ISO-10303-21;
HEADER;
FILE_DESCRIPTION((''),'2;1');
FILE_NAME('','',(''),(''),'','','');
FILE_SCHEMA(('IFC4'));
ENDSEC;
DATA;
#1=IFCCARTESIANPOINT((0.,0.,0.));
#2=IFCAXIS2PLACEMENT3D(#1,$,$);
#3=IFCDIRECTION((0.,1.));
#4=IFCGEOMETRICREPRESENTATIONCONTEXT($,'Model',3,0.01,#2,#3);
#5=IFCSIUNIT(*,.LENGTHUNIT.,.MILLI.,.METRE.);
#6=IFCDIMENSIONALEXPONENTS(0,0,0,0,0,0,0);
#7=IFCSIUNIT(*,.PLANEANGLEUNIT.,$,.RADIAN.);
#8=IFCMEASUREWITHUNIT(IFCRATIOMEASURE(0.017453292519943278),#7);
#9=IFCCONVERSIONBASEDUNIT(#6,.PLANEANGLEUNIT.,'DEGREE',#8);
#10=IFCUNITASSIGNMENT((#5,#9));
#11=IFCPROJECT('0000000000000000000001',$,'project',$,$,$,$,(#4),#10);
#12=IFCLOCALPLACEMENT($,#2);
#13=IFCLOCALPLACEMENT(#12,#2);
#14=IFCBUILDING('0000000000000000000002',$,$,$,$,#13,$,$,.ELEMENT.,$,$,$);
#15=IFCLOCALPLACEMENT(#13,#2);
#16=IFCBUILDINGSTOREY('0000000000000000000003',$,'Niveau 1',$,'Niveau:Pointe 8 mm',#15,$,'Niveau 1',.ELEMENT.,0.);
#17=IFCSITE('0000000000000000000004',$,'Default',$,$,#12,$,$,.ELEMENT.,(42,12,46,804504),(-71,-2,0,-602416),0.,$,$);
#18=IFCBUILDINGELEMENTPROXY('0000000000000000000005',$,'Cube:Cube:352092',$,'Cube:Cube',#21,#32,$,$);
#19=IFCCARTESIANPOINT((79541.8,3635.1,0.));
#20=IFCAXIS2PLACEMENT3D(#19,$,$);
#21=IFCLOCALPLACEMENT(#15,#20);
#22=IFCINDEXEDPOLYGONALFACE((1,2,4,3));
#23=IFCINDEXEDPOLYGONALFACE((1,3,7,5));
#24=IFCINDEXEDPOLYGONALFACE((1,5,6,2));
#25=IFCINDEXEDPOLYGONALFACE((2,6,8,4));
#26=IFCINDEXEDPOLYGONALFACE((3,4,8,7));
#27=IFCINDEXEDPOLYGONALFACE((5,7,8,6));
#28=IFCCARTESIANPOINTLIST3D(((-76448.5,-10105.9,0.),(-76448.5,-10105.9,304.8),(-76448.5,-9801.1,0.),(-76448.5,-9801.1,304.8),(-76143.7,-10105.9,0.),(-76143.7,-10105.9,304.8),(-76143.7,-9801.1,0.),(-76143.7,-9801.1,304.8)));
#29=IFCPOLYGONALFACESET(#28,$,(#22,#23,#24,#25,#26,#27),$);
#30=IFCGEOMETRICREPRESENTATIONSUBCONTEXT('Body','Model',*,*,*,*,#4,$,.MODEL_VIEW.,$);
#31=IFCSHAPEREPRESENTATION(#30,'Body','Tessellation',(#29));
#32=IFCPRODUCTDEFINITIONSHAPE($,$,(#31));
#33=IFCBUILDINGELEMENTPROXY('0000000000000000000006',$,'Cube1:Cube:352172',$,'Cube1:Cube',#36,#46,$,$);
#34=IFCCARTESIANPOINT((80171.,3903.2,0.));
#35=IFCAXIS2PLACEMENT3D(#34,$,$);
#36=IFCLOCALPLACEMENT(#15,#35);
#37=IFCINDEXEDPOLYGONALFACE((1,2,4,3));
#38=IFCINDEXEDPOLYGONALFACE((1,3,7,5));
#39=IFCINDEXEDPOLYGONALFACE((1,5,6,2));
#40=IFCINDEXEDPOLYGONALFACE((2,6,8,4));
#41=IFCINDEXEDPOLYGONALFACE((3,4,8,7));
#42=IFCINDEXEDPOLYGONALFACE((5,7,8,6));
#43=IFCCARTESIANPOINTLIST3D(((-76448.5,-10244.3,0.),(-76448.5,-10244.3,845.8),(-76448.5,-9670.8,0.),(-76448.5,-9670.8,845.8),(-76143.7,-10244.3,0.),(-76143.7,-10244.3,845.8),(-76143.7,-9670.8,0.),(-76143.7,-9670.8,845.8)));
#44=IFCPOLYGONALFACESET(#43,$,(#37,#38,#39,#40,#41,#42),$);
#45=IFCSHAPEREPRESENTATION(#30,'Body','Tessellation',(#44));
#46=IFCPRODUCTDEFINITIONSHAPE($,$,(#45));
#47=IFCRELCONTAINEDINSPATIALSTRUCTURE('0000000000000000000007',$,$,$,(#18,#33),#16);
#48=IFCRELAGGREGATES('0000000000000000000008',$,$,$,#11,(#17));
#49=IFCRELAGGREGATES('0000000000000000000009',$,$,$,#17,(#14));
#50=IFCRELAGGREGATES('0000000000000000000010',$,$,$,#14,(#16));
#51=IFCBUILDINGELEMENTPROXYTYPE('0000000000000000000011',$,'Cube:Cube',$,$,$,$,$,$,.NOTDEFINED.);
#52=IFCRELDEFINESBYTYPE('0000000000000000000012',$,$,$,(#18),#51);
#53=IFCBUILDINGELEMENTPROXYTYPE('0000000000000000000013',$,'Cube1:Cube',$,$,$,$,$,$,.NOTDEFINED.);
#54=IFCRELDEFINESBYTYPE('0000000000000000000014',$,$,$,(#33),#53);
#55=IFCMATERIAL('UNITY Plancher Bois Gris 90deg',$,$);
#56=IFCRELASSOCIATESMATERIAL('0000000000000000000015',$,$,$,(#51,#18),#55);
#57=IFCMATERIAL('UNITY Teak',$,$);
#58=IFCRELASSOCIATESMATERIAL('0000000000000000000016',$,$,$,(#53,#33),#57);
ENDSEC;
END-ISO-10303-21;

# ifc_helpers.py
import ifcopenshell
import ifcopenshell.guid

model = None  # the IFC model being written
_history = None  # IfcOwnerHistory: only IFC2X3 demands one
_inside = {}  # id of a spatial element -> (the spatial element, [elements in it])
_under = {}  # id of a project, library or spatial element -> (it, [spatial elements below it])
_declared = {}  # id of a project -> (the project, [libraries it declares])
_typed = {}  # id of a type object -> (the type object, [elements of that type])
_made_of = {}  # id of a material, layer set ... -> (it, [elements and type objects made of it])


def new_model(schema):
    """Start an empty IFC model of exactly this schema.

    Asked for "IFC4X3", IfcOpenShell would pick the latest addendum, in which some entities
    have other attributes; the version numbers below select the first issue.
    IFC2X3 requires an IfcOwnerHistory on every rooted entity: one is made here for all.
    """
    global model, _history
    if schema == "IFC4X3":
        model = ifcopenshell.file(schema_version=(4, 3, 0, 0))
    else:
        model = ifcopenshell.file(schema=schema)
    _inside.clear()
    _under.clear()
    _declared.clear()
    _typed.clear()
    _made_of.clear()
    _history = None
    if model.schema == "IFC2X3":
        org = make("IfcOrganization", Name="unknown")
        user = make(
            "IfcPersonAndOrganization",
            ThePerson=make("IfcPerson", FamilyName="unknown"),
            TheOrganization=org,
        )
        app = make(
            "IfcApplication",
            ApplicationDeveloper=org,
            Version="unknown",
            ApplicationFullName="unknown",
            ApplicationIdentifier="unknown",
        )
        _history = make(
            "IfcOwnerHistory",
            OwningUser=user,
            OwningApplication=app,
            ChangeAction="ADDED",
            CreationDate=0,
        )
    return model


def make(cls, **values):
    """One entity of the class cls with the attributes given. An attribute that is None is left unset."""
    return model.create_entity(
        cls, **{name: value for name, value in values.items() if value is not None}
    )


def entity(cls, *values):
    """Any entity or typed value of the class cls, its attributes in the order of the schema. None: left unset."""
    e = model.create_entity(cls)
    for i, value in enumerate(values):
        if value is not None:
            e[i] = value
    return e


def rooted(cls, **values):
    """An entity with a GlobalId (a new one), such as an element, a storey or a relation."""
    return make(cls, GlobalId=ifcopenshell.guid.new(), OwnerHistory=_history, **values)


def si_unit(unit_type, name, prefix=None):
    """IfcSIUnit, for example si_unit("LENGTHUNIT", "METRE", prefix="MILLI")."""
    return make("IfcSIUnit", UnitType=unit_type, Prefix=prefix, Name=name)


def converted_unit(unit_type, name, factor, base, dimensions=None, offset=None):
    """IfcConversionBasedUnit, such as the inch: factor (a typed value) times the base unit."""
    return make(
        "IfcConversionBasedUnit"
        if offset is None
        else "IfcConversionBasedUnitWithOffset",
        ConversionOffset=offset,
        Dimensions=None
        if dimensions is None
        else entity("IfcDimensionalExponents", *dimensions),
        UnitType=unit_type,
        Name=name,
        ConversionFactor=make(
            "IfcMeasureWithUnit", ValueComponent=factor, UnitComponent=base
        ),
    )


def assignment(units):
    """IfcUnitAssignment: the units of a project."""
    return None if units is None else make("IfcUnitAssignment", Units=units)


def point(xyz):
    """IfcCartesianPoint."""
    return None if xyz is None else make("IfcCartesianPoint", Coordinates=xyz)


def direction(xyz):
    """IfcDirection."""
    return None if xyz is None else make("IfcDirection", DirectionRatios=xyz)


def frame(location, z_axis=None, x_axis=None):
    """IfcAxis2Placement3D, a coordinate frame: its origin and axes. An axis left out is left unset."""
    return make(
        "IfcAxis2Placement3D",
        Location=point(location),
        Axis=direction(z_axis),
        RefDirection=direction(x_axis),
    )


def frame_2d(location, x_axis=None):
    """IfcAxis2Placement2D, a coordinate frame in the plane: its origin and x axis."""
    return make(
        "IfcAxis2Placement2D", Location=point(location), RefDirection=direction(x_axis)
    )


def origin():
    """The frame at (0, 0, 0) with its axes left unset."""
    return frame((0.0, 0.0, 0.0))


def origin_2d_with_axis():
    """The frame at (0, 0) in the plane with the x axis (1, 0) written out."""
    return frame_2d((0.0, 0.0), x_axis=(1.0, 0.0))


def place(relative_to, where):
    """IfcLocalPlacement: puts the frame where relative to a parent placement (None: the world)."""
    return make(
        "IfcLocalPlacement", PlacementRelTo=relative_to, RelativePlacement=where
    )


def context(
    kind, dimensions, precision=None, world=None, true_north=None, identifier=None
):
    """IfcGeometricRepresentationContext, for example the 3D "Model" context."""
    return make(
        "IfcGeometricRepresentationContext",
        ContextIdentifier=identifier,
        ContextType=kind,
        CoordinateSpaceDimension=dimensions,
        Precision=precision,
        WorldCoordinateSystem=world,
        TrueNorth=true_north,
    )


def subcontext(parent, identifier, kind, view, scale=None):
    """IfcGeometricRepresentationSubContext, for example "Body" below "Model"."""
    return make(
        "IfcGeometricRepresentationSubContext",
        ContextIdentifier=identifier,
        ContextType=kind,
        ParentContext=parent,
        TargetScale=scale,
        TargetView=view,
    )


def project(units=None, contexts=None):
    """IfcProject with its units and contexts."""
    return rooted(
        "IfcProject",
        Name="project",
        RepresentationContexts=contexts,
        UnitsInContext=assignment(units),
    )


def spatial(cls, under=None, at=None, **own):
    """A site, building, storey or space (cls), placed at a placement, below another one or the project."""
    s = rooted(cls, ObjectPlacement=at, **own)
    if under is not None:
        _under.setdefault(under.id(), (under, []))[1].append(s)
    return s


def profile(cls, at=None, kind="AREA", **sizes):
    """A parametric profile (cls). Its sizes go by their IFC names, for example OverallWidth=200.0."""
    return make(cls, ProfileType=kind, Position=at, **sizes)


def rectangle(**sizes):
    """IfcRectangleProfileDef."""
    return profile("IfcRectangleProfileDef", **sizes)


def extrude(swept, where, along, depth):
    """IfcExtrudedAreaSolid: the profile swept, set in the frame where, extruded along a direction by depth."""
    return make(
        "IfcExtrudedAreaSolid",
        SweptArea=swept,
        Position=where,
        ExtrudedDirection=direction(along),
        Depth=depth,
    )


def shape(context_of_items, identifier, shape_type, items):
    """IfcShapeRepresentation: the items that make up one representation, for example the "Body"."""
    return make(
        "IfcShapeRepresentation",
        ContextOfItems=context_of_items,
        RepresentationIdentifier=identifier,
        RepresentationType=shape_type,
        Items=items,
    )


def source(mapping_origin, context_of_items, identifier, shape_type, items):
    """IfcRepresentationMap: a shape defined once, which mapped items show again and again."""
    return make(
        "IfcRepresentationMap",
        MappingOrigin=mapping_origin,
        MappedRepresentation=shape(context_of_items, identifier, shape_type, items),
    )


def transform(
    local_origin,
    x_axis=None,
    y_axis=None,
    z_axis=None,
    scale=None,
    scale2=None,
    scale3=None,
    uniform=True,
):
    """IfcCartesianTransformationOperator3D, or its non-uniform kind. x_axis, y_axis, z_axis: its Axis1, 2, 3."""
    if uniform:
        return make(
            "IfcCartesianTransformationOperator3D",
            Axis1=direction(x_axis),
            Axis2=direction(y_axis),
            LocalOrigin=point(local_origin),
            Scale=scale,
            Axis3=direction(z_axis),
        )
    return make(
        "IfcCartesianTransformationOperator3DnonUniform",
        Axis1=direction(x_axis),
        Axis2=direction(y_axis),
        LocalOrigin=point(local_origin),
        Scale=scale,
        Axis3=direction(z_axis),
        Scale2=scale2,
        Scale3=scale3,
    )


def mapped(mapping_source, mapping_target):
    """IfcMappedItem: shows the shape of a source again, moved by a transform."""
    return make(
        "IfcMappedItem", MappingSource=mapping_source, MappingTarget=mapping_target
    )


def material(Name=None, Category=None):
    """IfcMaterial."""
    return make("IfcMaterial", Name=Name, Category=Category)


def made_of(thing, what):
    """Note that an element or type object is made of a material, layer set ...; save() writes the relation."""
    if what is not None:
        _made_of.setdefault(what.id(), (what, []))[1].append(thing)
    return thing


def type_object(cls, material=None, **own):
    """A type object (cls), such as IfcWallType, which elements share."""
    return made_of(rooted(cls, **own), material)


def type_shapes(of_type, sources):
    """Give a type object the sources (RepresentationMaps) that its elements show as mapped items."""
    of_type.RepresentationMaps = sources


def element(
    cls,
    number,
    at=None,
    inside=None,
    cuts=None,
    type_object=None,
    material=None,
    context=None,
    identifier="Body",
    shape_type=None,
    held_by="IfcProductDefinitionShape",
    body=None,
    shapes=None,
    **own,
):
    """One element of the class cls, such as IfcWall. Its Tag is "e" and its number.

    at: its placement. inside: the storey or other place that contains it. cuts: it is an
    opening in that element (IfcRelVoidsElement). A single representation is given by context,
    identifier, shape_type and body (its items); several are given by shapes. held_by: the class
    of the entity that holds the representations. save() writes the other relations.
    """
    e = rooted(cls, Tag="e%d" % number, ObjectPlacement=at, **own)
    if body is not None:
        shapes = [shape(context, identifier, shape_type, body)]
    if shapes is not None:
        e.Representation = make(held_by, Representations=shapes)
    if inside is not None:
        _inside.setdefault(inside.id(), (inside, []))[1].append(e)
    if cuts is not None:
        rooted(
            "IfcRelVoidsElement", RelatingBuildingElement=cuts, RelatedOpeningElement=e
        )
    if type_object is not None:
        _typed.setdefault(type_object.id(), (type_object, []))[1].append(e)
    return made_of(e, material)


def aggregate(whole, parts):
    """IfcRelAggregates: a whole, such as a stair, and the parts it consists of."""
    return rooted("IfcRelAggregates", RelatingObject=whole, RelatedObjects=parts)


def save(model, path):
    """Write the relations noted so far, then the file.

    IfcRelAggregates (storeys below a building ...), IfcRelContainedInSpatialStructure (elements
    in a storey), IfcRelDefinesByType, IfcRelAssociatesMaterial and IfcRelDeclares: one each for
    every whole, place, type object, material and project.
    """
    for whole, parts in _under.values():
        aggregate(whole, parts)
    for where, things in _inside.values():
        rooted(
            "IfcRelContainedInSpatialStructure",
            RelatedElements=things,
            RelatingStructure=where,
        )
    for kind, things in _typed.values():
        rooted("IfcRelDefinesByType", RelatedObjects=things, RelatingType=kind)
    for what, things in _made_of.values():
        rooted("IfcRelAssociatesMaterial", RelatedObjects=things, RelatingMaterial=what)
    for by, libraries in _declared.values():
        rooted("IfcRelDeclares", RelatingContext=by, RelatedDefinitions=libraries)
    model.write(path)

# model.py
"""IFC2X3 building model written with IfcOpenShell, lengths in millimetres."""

from ifc_helpers import new_model, entity, si_unit, converted_unit, direction, frame, frame_2d, origin, origin_2d_with_axis, place, context, subcontext, project, spatial, rectangle, extrude, source, transform, mapped, material, type_object, type_shapes, element, save


model = new_model("IFC2X3")

# Units and contexts
model_context = context("Model", 3, precision=0.01, world=origin(), true_north=direction((0.0, 1.0)))
body_context = subcontext(model_context, "Body", "Model", "MODEL_VIEW")
ifc_project = project(units=[si_unit("LENGTHUNIT", "METRE", prefix="MILLI"), converted_unit("PLANEANGLEUNIT", "DEGREE", entity("IfcRatioMeasure", 0.017453292519943278), si_unit("PLANEANGLEUNIT", "RADIAN"), dimensions=[0, 0, 0, 0, 0, 0, 0])], contexts=[model_context])

# Site, building, storey
site_placement = place(None, origin())
site = spatial("IfcSite", under=ifc_project, at=site_placement, Name="Default", CompositionType="ELEMENT", RefLatitude=(42, 12, 46, 804504), RefLongitude=(-71, -2, 0, -602416), RefElevation=0.0)
building_placement = place(site_placement, origin())
building = spatial("IfcBuilding", under=site, at=building_placement, CompositionType="ELEMENT")
storey_placement = place(building_placement, origin())
storey = spatial("IfcBuildingStorey", under=building, at=storey_placement, Name="Niveau 1", ObjectType="Niveau:Pointe 8 mm", LongName="Niveau 1", CompositionType="ELEMENT", Elevation=0.0)

# Building element proxies
ifc_material_1 = material(Name="UNITY Plancher Bois Gris 90deg")
building_element_proxy_type_1 = type_object("IfcBuildingElementProxyType", Name="Cube:Cube", PredefinedType="NOTDEFINED", material=ifc_material_1)
shared_shape_1 = source(origin(), body_context, "Body", "SweptSolid", [
    extrude(rectangle(XDim=304.8, YDim=304.8, at=origin_2d_with_axis()), frame((-76296.1, -9953.5, 0.0), z_axis=(0.0, 0.0, 1.0), x_axis=(0.0, -1.0, 0.0)), (0.0, 0.0, 1.0), 304.8),
])
type_shapes(building_element_proxy_type_1, [shared_shape_1])
proxy_1_placement = place(storey_placement, frame((79541.8, 3635.1, 0.0)))
element("IfcBuildingElementProxy", 1, at=proxy_1_placement, inside=storey, type_object=building_element_proxy_type_1, material=ifc_material_1, Name="Cube:Cube:352092", ObjectType="Cube:Cube", context=body_context, shape_type="MappedRepresentation", body=[
    mapped(shared_shape_1, transform((0.0, 0.0, 0.0), scale=1.0)),
])
ifc_material_2 = material(Name="UNITY Teak")
building_element_proxy_type_2 = type_object("IfcBuildingElementProxyType", Name="Cube1:Cube", PredefinedType="NOTDEFINED", material=ifc_material_2)
shared_shape_2 = source(origin(), body_context, "Body", "SweptSolid", [
    extrude(rectangle(XDim=573.5, YDim=304.8, at=frame_2d((0.0, 0.0), x_axis=(1.0, 0.0))), frame((-76296.1, -9957.5, 0.0), z_axis=(0.0, 0.0, 1.0), x_axis=(0.0, -1.0, 0.0)), (0.0, 0.0, 1.0), 845.8),
])
type_shapes(building_element_proxy_type_2, [shared_shape_2])
proxy_2_placement = place(storey_placement, frame((80171.0, 3903.2, 0.0)))
element("IfcBuildingElementProxy", 2, at=proxy_2_placement, inside=storey, type_object=building_element_proxy_type_2, material=ifc_material_2, Name="Cube1:Cube:352172", ObjectType="Cube1:Cube", context=body_context, shape_type="MappedRepresentation", body=[
    mapped(shared_shape_2, transform((0.0, 0.0, 0.0), scale=1.0)),
])

save(model, "model.ifc")
